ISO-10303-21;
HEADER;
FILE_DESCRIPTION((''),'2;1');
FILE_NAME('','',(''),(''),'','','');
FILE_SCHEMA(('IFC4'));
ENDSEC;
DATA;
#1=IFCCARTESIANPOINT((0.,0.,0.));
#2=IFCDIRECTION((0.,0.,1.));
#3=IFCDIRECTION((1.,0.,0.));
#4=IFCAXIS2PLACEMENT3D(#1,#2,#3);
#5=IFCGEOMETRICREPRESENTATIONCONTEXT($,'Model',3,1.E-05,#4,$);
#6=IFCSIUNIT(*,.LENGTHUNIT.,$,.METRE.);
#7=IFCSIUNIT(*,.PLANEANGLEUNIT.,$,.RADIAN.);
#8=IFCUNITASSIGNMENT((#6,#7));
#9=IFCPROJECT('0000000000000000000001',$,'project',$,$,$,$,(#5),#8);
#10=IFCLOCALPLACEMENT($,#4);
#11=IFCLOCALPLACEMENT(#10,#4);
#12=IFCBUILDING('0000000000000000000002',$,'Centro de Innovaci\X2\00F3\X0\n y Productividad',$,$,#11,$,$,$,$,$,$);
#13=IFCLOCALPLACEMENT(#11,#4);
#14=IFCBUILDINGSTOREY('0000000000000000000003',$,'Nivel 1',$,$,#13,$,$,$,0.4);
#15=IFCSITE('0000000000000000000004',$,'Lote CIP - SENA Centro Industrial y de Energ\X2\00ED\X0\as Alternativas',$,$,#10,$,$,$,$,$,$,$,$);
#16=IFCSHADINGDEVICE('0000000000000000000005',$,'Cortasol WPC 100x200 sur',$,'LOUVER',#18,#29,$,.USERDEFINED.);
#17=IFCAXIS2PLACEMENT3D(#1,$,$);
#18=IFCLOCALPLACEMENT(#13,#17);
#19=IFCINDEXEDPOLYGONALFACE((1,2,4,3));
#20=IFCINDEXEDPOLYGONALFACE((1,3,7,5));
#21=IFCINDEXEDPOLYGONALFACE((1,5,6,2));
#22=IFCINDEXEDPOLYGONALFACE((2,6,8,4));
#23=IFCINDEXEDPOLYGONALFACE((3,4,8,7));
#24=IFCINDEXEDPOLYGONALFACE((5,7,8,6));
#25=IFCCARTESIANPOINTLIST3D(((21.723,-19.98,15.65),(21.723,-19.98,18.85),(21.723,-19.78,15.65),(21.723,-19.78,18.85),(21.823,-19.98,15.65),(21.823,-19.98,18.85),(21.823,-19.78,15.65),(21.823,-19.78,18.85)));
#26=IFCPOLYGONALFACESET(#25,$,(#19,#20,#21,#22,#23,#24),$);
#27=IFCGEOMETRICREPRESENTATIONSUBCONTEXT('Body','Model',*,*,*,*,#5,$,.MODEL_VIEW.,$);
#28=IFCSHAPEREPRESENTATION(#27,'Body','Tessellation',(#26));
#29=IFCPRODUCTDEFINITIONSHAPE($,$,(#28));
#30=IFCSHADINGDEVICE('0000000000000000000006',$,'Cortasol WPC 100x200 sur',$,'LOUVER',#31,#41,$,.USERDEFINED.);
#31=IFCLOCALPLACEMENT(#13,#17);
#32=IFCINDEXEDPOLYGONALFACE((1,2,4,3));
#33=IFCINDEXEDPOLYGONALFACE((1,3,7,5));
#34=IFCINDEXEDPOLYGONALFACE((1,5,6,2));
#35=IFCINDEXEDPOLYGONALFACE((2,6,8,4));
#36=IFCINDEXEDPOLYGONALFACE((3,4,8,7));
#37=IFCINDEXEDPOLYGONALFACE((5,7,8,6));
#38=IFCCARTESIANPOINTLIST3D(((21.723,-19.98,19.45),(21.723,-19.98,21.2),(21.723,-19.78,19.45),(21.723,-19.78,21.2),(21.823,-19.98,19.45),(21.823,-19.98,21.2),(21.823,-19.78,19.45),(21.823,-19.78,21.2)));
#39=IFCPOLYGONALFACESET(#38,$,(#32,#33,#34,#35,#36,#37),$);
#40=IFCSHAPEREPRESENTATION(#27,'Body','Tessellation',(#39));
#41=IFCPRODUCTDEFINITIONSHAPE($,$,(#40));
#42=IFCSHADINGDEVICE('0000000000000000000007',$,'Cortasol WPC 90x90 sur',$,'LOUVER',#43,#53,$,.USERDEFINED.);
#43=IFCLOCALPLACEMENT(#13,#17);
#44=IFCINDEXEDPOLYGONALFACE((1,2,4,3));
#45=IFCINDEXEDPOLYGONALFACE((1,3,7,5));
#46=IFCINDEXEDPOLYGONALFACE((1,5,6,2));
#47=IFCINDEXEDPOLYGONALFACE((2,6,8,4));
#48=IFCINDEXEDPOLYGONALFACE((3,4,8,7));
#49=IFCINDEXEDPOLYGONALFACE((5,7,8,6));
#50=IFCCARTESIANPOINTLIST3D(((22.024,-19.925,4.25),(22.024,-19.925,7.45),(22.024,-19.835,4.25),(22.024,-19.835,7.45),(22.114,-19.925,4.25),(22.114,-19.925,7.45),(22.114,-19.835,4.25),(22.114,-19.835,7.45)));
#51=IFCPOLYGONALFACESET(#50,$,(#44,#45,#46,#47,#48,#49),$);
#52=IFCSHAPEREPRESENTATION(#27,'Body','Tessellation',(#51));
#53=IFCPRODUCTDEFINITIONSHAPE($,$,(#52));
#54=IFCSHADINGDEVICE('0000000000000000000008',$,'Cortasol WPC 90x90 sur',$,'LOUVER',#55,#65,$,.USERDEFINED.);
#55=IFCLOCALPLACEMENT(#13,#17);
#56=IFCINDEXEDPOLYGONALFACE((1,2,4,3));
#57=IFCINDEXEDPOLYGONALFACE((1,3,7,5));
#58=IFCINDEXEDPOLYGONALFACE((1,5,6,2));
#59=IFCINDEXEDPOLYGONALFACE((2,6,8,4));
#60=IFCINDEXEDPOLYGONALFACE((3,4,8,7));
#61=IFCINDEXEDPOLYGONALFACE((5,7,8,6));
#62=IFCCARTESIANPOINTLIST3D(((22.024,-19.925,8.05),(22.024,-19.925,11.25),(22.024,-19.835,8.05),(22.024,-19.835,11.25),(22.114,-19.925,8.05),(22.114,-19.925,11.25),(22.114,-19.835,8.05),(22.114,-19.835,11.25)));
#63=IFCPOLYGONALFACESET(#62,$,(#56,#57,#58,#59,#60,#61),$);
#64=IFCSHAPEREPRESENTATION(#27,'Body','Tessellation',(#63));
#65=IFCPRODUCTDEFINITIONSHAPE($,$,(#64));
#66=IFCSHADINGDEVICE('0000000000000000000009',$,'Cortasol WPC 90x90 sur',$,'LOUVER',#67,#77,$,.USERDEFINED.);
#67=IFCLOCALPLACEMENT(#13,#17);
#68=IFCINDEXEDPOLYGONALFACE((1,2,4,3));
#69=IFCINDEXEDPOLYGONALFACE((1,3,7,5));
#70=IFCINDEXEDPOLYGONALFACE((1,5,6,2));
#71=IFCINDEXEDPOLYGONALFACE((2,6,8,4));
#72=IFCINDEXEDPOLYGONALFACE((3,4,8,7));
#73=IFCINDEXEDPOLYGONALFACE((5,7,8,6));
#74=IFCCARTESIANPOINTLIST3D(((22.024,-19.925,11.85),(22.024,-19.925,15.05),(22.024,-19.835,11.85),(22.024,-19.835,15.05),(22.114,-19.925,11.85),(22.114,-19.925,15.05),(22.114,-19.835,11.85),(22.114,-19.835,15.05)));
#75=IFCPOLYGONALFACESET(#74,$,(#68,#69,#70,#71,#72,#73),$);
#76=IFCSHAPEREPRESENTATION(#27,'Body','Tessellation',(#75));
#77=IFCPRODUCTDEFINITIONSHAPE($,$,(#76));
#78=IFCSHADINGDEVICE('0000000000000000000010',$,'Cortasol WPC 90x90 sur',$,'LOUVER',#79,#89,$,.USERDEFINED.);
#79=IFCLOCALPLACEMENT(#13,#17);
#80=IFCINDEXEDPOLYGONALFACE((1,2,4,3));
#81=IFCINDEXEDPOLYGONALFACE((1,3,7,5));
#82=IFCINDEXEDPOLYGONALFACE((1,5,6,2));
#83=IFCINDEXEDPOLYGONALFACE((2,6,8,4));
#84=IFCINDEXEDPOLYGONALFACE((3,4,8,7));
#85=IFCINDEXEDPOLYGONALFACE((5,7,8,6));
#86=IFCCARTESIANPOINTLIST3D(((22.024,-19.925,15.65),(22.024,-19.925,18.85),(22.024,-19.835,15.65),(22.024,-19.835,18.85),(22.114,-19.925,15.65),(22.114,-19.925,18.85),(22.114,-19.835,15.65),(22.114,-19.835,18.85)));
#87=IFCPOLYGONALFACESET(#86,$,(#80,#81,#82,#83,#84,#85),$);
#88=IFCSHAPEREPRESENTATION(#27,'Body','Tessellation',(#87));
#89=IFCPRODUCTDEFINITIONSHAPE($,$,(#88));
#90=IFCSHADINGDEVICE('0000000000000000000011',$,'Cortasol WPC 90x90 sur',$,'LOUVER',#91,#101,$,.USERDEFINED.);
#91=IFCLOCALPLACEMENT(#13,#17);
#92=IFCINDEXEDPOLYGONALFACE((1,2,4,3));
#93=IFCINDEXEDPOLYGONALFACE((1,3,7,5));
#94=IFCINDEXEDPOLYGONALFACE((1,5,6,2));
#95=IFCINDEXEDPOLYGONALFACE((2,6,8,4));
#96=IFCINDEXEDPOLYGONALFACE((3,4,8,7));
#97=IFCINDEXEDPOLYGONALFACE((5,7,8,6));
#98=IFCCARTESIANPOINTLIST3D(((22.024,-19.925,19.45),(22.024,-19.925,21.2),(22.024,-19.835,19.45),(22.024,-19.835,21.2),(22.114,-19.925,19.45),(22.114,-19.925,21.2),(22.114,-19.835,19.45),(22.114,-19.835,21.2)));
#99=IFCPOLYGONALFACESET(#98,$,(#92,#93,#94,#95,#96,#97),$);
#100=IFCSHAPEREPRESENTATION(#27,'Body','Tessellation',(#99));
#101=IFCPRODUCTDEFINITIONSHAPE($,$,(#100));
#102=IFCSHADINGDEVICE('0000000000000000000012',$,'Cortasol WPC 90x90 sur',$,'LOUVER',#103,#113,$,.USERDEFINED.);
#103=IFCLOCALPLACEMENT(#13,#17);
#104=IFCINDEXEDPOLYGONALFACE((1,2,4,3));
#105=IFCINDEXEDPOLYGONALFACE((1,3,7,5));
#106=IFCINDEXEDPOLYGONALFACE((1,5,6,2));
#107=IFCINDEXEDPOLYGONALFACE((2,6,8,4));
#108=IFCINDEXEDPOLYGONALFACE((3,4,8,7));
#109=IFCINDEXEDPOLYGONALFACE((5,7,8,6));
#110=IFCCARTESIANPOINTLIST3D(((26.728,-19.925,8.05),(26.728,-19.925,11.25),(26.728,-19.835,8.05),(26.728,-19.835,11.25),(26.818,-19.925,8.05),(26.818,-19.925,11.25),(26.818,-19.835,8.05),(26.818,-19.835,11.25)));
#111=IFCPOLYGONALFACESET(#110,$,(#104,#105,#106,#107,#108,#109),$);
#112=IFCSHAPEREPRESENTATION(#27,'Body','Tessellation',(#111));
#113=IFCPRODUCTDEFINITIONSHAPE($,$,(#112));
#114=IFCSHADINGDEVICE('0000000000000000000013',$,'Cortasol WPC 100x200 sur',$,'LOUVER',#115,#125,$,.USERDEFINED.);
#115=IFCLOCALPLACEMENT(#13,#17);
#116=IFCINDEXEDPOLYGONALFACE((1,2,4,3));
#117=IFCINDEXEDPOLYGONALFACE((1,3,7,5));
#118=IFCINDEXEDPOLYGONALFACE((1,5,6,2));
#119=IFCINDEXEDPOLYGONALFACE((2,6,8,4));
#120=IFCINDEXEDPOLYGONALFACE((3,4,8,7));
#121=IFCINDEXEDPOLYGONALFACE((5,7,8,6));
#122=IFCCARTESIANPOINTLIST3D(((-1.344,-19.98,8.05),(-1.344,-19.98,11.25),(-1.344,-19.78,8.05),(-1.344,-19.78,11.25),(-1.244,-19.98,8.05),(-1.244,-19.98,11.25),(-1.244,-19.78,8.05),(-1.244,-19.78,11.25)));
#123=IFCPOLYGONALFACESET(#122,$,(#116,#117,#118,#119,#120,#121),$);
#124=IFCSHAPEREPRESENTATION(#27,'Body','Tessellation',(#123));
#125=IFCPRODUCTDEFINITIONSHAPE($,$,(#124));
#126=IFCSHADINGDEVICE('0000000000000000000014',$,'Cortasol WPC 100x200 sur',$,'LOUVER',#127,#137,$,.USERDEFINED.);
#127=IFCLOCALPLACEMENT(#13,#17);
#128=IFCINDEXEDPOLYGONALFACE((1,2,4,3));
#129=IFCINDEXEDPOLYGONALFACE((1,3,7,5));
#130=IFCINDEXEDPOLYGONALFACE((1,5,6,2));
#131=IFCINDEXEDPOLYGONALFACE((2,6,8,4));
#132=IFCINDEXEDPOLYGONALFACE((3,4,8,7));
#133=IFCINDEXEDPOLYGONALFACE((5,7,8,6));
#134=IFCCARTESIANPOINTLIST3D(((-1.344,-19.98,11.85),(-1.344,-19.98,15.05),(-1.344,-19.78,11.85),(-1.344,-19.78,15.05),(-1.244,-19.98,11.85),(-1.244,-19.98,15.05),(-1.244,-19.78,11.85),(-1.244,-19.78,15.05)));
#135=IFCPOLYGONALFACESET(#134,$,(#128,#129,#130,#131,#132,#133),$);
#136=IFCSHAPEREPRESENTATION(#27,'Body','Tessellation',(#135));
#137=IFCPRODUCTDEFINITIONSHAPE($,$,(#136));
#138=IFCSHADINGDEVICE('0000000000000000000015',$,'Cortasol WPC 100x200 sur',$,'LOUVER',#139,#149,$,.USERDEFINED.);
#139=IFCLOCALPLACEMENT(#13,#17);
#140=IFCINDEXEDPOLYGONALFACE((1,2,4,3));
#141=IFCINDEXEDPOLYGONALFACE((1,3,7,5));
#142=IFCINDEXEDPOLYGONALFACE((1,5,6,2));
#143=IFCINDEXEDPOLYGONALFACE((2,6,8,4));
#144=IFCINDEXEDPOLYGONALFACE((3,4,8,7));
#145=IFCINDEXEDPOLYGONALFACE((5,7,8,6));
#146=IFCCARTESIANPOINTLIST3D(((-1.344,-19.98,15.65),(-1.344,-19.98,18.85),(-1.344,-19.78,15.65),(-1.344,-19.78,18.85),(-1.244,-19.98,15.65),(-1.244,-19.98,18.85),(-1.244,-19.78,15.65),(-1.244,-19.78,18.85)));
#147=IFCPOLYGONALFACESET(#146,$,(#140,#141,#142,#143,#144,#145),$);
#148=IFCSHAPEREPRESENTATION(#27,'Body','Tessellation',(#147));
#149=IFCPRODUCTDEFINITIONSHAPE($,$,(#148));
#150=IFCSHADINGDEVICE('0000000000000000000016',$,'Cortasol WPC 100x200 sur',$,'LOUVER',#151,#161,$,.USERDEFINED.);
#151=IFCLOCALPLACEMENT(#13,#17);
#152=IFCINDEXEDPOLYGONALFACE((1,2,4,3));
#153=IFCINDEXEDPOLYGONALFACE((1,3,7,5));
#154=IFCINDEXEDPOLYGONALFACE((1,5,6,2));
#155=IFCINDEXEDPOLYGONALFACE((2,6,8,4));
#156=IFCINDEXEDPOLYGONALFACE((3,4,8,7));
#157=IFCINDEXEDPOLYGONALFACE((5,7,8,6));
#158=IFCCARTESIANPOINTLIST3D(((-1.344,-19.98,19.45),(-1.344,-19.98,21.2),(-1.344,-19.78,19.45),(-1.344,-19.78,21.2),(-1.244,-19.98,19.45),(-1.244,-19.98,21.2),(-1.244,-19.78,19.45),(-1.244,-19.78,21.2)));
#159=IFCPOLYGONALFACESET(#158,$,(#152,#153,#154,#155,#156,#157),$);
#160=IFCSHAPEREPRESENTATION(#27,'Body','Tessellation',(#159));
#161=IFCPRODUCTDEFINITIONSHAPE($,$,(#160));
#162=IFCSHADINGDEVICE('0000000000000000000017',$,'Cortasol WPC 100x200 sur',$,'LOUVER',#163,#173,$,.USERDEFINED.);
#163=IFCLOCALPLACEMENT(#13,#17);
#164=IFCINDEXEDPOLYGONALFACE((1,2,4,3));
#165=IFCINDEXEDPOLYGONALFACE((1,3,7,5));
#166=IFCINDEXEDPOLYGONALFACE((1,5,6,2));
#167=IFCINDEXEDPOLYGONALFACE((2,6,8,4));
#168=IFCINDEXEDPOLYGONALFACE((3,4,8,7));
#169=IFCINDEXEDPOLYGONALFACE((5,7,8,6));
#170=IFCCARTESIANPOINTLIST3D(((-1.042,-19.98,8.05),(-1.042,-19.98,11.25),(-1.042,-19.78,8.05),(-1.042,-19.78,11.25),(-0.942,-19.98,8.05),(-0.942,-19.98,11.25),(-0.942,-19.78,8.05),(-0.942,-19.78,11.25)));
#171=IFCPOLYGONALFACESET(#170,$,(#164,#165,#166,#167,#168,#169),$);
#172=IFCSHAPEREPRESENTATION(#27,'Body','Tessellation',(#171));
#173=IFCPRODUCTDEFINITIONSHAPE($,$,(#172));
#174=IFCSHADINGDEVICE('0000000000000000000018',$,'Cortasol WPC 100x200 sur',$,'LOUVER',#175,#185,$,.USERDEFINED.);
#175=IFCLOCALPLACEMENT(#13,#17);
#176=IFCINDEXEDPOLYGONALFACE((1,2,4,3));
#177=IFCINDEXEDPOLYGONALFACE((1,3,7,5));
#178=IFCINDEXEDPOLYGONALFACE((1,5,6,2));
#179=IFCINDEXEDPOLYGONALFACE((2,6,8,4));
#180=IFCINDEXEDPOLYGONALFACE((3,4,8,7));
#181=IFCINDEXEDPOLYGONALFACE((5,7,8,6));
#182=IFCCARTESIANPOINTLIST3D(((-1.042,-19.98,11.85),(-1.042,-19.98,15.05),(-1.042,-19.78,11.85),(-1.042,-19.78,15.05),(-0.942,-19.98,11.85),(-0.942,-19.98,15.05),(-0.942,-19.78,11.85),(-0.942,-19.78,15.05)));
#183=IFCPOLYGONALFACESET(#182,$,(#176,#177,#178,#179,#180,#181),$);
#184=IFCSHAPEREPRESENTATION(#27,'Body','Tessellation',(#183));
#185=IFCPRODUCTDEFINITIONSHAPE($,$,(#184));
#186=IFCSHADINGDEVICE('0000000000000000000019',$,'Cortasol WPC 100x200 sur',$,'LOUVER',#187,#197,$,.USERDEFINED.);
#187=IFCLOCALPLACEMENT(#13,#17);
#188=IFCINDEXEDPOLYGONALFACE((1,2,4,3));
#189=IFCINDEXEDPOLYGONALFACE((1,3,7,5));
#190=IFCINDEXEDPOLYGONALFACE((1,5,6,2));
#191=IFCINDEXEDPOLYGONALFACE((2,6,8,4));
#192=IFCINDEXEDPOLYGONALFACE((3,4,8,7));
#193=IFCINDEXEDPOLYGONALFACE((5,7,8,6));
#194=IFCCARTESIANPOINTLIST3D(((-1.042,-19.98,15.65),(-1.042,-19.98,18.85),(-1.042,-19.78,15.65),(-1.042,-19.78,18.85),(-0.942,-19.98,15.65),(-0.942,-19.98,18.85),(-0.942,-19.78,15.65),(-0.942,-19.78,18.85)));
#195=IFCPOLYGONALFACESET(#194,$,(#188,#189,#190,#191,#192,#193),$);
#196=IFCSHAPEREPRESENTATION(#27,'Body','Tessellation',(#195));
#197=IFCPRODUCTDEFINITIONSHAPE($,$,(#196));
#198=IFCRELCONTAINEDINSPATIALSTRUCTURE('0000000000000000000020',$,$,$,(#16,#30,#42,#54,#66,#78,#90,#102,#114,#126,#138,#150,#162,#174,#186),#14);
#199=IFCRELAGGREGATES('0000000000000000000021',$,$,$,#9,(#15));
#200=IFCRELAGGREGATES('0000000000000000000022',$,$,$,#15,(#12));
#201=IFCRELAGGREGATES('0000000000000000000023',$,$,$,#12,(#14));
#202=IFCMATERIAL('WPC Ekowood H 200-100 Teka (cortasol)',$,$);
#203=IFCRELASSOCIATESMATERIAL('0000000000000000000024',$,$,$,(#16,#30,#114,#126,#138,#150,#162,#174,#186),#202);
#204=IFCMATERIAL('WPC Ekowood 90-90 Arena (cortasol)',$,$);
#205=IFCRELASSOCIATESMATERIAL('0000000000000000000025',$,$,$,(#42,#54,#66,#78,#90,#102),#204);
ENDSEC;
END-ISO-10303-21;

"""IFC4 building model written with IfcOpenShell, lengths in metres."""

from ifc_helpers import new_model, si_unit, frame, origin_with_axes, place, context, subcontext, project, spatial, polyline, outline, extrude, material, element, save


model = new_model("IFC4")

# Units and contexts
model_context = context("Model", 3, precision=1e-05, world=origin_with_axes())
body_context = subcontext(model_context, "Body", "Model", "MODEL_VIEW")
ifc_project = project(units=[si_unit("LENGTHUNIT", "METRE"), si_unit("PLANEANGLEUNIT", "RADIAN")], contexts=[model_context])

# Site, building, storey
site_placement = place(None, origin_with_axes())
site = spatial("IfcSite", under=ifc_project, at=site_placement, Name="Lote CIP - SENA Centro Industrial y de Energías Alternativas")
building_placement = place(site_placement, origin_with_axes())
building = spatial("IfcBuilding", under=site, at=building_placement, Name="Centro de Innovación y Productividad")
storey_placement = place(building_placement, origin_with_axes())
storey = spatial("IfcBuildingStorey", under=building, at=storey_placement, Name="Nivel 1", Elevation=0.4)

# Shading devices
ifc_material_1 = material(Name="WPC Ekowood H 200-100 Teka (cortasol)")
shading_device_1_placement = place(storey_placement, origin_with_axes())
element("IfcShadingDevice", 1, at=shading_device_1_placement, inside=storey, material=ifc_material_1, Name="Cortasol WPC 100x200 sur", ObjectType="LOUVER", PredefinedType="USERDEFINED", context=body_context, shape_type="SweptSolid", body=[
    extrude(outline(polyline([(21.723, -19.98), (21.723, -19.78), (21.823, -19.78), (21.823, -19.98), (21.723, -19.98)])), frame((0.0, 0.0, 15.65)), (0.0, 0.0, 1.0), 3.2),
])
shading_device_2_placement = place(storey_placement, origin_with_axes())
element("IfcShadingDevice", 2, at=shading_device_2_placement, inside=storey, material=ifc_material_1, Name="Cortasol WPC 100x200 sur", ObjectType="LOUVER", PredefinedType="USERDEFINED", context=body_context, shape_type="SweptSolid", body=[
    extrude(outline(polyline([(21.723, -19.98), (21.723, -19.78), (21.823, -19.78), (21.823, -19.98), (21.723, -19.98)])), frame((0.0, 0.0, 19.45)), (0.0, 0.0, 1.0), 1.75),
])
ifc_material_2 = material(Name="WPC Ekowood 90-90 Arena (cortasol)")
shading_device_3_placement = place(storey_placement, origin_with_axes())
element("IfcShadingDevice", 3, at=shading_device_3_placement, inside=storey, material=ifc_material_2, Name="Cortasol WPC 90x90 sur", ObjectType="LOUVER", PredefinedType="USERDEFINED", context=body_context, shape_type="SweptSolid", body=[
    extrude(outline(polyline([(22.024, -19.925), (22.024, -19.835), (22.114, -19.835), (22.114, -19.925), (22.024, -19.925)])), frame((0.0, 0.0, 4.25)), (0.0, 0.0, 1.0), 3.2),
])
shading_device_4_placement = place(storey_placement, origin_with_axes())
element("IfcShadingDevice", 4, at=shading_device_4_placement, inside=storey, material=ifc_material_2, Name="Cortasol WPC 90x90 sur", ObjectType="LOUVER", PredefinedType="USERDEFINED", context=body_context, shape_type="SweptSolid", body=[
    extrude(outline(polyline([(22.024, -19.925), (22.024, -19.835), (22.114, -19.835), (22.114, -19.925), (22.024, -19.925)])), frame((0.0, 0.0, 8.05)), (0.0, 0.0, 1.0), 3.2),
])
shading_device_5_placement = place(storey_placement, origin_with_axes())
element("IfcShadingDevice", 5, at=shading_device_5_placement, inside=storey, material=ifc_material_2, Name="Cortasol WPC 90x90 sur", ObjectType="LOUVER", PredefinedType="USERDEFINED", context=body_context, shape_type="SweptSolid", body=[
    extrude(outline(polyline([(22.024, -19.925), (22.024, -19.835), (22.114, -19.835), (22.114, -19.925), (22.024, -19.925)])), frame((0.0, 0.0, 11.85)), (0.0, 0.0, 1.0), 3.2),
])
shading_device_6_placement = place(storey_placement, origin_with_axes())
element("IfcShadingDevice", 6, at=shading_device_6_placement, inside=storey, material=ifc_material_2, Name="Cortasol WPC 90x90 sur", ObjectType="LOUVER", PredefinedType="USERDEFINED", context=body_context, shape_type="SweptSolid", body=[
    extrude(outline(polyline([(22.024, -19.925), (22.024, -19.835), (22.114, -19.835), (22.114, -19.925), (22.024, -19.925)])), frame((0.0, 0.0, 15.65)), (0.0, 0.0, 1.0), 3.2),
])
shading_device_7_placement = place(storey_placement, origin_with_axes())
element("IfcShadingDevice", 7, at=shading_device_7_placement, inside=storey, material=ifc_material_2, Name="Cortasol WPC 90x90 sur", ObjectType="LOUVER", PredefinedType="USERDEFINED", context=body_context, shape_type="SweptSolid", body=[
    extrude(outline(polyline([(22.024, -19.925), (22.024, -19.835), (22.114, -19.835), (22.114, -19.925), (22.024, -19.925)])), frame((0.0, 0.0, 19.45)), (0.0, 0.0, 1.0), 1.75),
])
shading_device_8_placement = place(storey_placement, origin_with_axes())
element("IfcShadingDevice", 8, at=shading_device_8_placement, inside=storey, material=ifc_material_2, Name="Cortasol WPC 90x90 sur", ObjectType="LOUVER", PredefinedType="USERDEFINED", context=body_context, shape_type="SweptSolid", body=[
    extrude(outline(polyline([(26.728, -19.925), (26.728, -19.835), (26.818, -19.835), (26.818, -19.925), (26.728, -19.925)])), frame((0.0, 0.0, 8.05)), (0.0, 0.0, 1.0), 3.2),
])
shading_device_9_placement = place(storey_placement, origin_with_axes())
element("IfcShadingDevice", 9, at=shading_device_9_placement, inside=storey, material=ifc_material_1, Name="Cortasol WPC 100x200 sur", ObjectType="LOUVER", PredefinedType="USERDEFINED", context=body_context, shape_type="SweptSolid", body=[
    extrude(outline(polyline([(-1.344, -19.98), (-1.344, -19.78), (-1.244, -19.78), (-1.244, -19.98), (-1.344, -19.98)])), frame((0.0, 0.0, 8.05)), (0.0, 0.0, 1.0), 3.2),
])
shading_device_10_placement = place(storey_placement, origin_with_axes())
element("IfcShadingDevice", 10, at=shading_device_10_placement, inside=storey, material=ifc_material_1, Name="Cortasol WPC 100x200 sur", ObjectType="LOUVER", PredefinedType="USERDEFINED", context=body_context, shape_type="SweptSolid", body=[
    extrude(outline(polyline([(-1.344, -19.98), (-1.344, -19.78), (-1.244, -19.78), (-1.244, -19.98), (-1.344, -19.98)])), frame((0.0, 0.0, 11.85)), (0.0, 0.0, 1.0), 3.2),
])
shading_device_11_placement = place(storey_placement, origin_with_axes())
element("IfcShadingDevice", 11, at=shading_device_11_placement, inside=storey, material=ifc_material_1, Name="Cortasol WPC 100x200 sur", ObjectType="LOUVER", PredefinedType="USERDEFINED", context=body_context, shape_type="SweptSolid", body=[
    extrude(outline(polyline([(-1.344, -19.98), (-1.344, -19.78), (-1.244, -19.78), (-1.244, -19.98), (-1.344, -19.98)])), frame((0.0, 0.0, 15.65)), (0.0, 0.0, 1.0), 3.2),
])
shading_device_12_placement = place(storey_placement, origin_with_axes())
element("IfcShadingDevice", 12, at=shading_device_12_placement, inside=storey, material=ifc_material_1, Name="Cortasol WPC 100x200 sur", ObjectType="LOUVER", PredefinedType="USERDEFINED", context=body_context, shape_type="SweptSolid", body=[
    extrude(outline(polyline([(-1.344, -19.98), (-1.344, -19.78), (-1.244, -19.78), (-1.244, -19.98), (-1.344, -19.98)])), frame((0.0, 0.0, 19.45)), (0.0, 0.0, 1.0), 1.75),
])
shading_device_13_placement = place(storey_placement, origin_with_axes())
element("IfcShadingDevice", 13, at=shading_device_13_placement, inside=storey, material=ifc_material_1, Name="Cortasol WPC 100x200 sur", ObjectType="LOUVER", PredefinedType="USERDEFINED", context=body_context, shape_type="SweptSolid", body=[
    extrude(outline(polyline([(-1.042, -19.98), (-1.042, -19.78), (-0.942, -19.78), (-0.942, -19.98), (-1.042, -19.98)])), frame((0.0, 0.0, 8.05)), (0.0, 0.0, 1.0), 3.2),
])
shading_device_14_placement = place(storey_placement, origin_with_axes())
element("IfcShadingDevice", 14, at=shading_device_14_placement, inside=storey, material=ifc_material_1, Name="Cortasol WPC 100x200 sur", ObjectType="LOUVER", PredefinedType="USERDEFINED", context=body_context, shape_type="SweptSolid", body=[
    extrude(outline(polyline([(-1.042, -19.98), (-1.042, -19.78), (-0.942, -19.78), (-0.942, -19.98), (-1.042, -19.98)])), frame((0.0, 0.0, 11.85)), (0.0, 0.0, 1.0), 3.2),
])
shading_device_15_placement = place(storey_placement, origin_with_axes())
element("IfcShadingDevice", 15, at=shading_device_15_placement, inside=storey, material=ifc_material_1, Name="Cortasol WPC 100x200 sur", ObjectType="LOUVER", PredefinedType="USERDEFINED", context=body_context, shape_type="SweptSolid", body=[
    extrude(outline(polyline([(-1.042, -19.98), (-1.042, -19.78), (-0.942, -19.78), (-0.942, -19.98), (-1.042, -19.98)])), frame((0.0, 0.0, 15.65)), (0.0, 0.0, 1.0), 3.2),
])

save(model, "model.ifc")
